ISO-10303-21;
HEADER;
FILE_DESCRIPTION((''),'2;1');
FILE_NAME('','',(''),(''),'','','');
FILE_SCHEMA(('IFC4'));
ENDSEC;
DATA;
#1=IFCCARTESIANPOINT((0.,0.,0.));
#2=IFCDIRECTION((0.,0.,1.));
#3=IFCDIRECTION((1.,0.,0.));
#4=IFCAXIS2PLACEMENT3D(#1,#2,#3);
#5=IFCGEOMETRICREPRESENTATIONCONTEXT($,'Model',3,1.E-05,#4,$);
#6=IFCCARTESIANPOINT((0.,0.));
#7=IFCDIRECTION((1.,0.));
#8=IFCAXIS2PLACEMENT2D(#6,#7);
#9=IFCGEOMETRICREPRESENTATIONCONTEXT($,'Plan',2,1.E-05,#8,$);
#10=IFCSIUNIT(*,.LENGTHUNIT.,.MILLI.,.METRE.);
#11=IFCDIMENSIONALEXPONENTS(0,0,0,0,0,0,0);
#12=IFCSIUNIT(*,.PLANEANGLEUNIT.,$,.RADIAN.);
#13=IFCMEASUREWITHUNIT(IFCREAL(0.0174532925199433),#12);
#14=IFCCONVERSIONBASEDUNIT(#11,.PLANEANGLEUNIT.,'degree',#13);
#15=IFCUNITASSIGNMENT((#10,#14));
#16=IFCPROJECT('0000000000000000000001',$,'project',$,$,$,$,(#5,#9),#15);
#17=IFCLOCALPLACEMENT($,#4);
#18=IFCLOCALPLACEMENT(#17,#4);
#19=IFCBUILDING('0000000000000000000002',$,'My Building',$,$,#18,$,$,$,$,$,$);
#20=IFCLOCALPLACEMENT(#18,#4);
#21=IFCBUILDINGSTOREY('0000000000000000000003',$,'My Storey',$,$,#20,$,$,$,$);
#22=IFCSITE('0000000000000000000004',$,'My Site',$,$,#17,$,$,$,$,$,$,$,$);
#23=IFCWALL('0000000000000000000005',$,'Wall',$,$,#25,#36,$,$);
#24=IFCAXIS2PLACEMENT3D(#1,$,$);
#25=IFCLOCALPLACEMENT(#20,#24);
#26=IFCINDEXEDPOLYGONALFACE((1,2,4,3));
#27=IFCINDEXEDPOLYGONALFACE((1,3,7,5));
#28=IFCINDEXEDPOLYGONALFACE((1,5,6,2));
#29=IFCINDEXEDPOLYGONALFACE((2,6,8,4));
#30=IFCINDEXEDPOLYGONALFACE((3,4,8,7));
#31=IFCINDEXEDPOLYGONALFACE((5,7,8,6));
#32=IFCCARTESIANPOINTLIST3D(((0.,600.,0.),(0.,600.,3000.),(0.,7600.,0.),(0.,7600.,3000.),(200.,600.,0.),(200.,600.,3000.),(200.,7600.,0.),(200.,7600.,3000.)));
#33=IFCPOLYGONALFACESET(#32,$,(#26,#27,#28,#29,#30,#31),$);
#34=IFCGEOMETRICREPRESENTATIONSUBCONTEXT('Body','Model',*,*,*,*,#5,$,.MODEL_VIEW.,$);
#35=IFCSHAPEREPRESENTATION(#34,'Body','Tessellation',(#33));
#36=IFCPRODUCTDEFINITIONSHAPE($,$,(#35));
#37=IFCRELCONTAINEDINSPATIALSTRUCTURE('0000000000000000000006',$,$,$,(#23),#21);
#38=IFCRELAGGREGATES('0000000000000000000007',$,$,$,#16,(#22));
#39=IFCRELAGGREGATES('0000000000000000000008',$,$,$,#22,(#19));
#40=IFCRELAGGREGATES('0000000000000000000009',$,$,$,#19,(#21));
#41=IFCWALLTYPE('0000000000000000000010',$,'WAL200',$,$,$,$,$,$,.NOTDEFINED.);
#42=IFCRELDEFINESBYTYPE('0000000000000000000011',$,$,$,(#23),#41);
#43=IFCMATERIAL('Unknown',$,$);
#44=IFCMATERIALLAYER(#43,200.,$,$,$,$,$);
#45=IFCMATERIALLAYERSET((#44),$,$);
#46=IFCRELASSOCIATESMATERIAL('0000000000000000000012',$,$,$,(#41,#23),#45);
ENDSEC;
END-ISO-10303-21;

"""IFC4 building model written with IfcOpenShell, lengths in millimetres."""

from ifc_helpers import new_model, entity, si_unit, converted_unit, frame, origin_with_axes, origin_2d_with_axis, place, context, subcontext, project, spatial, indexed_curve, outline, extrude, material, layer, layer_set, layer_usage, type_object, element, save


model = new_model("IFC4")

# Units and contexts
model_context = context("Model", 3, precision=1e-05, world=origin_with_axes())
plan_context = context("Plan", 2, precision=1e-05, world=origin_2d_with_axis())
body_context = subcontext(model_context, "Body", "Model", "MODEL_VIEW")
ifc_project = project(units=[si_unit("LENGTHUNIT", "METRE", prefix="MILLI"), converted_unit("PLANEANGLEUNIT", "degree", entity("IfcReal", 0.0174532925199433), si_unit("PLANEANGLEUNIT", "RADIAN"), dimensions=[0, 0, 0, 0, 0, 0, 0])], contexts=[model_context, plan_context])

# Site, building, storey
site_placement = place(None, origin_with_axes())
site = spatial("IfcSite", under=ifc_project, at=site_placement, Name="My Site")
building_placement = place(site_placement, origin_with_axes())
building = spatial("IfcBuilding", under=site, at=building_placement, Name="My Building")
storey_placement = place(building_placement, origin_with_axes())
storey = spatial("IfcBuildingStorey", under=building, at=storey_placement, Name="My Storey")

# Shared definitions
ifc_material = material(Name="Unknown")

# Wall
ifc_layer_1 = layer(ifc_material, 200.0)
ifc_layer_set_1 = layer_set([ifc_layer_1])
wall_type = type_object("IfcWallType", Name="WAL200", PredefinedType="NOTDEFINED", material=ifc_layer_set_1)
ifc_layer_usage_1 = layer_usage(ifc_layer_set_1, "AXIS2", "POSITIVE", 0.0)
wall_1_placement = place(storey_placement, frame((0.0, 7600.0, 0.0), z_axis=(0.0, 0.0, 1.0), x_axis=(0.0, -1.0, 0.0)))
element("IfcWall", 1, at=wall_1_placement, inside=storey, type_object=wall_type, material=ifc_layer_usage_1, Name="Wall", context=body_context, shape_type="SweptSolid", body=[
    extrude(outline(indexed_curve([(0.0, 0.0), (0.0, 200.0), (7000.0, 200.0), (7000.0, 0.0), (0.0, 0.0)], self_intersect=False)), origin_with_axes(), (0.0, 0.0, 1.0), 3000.0),
])

save(model, "model.ifc")
